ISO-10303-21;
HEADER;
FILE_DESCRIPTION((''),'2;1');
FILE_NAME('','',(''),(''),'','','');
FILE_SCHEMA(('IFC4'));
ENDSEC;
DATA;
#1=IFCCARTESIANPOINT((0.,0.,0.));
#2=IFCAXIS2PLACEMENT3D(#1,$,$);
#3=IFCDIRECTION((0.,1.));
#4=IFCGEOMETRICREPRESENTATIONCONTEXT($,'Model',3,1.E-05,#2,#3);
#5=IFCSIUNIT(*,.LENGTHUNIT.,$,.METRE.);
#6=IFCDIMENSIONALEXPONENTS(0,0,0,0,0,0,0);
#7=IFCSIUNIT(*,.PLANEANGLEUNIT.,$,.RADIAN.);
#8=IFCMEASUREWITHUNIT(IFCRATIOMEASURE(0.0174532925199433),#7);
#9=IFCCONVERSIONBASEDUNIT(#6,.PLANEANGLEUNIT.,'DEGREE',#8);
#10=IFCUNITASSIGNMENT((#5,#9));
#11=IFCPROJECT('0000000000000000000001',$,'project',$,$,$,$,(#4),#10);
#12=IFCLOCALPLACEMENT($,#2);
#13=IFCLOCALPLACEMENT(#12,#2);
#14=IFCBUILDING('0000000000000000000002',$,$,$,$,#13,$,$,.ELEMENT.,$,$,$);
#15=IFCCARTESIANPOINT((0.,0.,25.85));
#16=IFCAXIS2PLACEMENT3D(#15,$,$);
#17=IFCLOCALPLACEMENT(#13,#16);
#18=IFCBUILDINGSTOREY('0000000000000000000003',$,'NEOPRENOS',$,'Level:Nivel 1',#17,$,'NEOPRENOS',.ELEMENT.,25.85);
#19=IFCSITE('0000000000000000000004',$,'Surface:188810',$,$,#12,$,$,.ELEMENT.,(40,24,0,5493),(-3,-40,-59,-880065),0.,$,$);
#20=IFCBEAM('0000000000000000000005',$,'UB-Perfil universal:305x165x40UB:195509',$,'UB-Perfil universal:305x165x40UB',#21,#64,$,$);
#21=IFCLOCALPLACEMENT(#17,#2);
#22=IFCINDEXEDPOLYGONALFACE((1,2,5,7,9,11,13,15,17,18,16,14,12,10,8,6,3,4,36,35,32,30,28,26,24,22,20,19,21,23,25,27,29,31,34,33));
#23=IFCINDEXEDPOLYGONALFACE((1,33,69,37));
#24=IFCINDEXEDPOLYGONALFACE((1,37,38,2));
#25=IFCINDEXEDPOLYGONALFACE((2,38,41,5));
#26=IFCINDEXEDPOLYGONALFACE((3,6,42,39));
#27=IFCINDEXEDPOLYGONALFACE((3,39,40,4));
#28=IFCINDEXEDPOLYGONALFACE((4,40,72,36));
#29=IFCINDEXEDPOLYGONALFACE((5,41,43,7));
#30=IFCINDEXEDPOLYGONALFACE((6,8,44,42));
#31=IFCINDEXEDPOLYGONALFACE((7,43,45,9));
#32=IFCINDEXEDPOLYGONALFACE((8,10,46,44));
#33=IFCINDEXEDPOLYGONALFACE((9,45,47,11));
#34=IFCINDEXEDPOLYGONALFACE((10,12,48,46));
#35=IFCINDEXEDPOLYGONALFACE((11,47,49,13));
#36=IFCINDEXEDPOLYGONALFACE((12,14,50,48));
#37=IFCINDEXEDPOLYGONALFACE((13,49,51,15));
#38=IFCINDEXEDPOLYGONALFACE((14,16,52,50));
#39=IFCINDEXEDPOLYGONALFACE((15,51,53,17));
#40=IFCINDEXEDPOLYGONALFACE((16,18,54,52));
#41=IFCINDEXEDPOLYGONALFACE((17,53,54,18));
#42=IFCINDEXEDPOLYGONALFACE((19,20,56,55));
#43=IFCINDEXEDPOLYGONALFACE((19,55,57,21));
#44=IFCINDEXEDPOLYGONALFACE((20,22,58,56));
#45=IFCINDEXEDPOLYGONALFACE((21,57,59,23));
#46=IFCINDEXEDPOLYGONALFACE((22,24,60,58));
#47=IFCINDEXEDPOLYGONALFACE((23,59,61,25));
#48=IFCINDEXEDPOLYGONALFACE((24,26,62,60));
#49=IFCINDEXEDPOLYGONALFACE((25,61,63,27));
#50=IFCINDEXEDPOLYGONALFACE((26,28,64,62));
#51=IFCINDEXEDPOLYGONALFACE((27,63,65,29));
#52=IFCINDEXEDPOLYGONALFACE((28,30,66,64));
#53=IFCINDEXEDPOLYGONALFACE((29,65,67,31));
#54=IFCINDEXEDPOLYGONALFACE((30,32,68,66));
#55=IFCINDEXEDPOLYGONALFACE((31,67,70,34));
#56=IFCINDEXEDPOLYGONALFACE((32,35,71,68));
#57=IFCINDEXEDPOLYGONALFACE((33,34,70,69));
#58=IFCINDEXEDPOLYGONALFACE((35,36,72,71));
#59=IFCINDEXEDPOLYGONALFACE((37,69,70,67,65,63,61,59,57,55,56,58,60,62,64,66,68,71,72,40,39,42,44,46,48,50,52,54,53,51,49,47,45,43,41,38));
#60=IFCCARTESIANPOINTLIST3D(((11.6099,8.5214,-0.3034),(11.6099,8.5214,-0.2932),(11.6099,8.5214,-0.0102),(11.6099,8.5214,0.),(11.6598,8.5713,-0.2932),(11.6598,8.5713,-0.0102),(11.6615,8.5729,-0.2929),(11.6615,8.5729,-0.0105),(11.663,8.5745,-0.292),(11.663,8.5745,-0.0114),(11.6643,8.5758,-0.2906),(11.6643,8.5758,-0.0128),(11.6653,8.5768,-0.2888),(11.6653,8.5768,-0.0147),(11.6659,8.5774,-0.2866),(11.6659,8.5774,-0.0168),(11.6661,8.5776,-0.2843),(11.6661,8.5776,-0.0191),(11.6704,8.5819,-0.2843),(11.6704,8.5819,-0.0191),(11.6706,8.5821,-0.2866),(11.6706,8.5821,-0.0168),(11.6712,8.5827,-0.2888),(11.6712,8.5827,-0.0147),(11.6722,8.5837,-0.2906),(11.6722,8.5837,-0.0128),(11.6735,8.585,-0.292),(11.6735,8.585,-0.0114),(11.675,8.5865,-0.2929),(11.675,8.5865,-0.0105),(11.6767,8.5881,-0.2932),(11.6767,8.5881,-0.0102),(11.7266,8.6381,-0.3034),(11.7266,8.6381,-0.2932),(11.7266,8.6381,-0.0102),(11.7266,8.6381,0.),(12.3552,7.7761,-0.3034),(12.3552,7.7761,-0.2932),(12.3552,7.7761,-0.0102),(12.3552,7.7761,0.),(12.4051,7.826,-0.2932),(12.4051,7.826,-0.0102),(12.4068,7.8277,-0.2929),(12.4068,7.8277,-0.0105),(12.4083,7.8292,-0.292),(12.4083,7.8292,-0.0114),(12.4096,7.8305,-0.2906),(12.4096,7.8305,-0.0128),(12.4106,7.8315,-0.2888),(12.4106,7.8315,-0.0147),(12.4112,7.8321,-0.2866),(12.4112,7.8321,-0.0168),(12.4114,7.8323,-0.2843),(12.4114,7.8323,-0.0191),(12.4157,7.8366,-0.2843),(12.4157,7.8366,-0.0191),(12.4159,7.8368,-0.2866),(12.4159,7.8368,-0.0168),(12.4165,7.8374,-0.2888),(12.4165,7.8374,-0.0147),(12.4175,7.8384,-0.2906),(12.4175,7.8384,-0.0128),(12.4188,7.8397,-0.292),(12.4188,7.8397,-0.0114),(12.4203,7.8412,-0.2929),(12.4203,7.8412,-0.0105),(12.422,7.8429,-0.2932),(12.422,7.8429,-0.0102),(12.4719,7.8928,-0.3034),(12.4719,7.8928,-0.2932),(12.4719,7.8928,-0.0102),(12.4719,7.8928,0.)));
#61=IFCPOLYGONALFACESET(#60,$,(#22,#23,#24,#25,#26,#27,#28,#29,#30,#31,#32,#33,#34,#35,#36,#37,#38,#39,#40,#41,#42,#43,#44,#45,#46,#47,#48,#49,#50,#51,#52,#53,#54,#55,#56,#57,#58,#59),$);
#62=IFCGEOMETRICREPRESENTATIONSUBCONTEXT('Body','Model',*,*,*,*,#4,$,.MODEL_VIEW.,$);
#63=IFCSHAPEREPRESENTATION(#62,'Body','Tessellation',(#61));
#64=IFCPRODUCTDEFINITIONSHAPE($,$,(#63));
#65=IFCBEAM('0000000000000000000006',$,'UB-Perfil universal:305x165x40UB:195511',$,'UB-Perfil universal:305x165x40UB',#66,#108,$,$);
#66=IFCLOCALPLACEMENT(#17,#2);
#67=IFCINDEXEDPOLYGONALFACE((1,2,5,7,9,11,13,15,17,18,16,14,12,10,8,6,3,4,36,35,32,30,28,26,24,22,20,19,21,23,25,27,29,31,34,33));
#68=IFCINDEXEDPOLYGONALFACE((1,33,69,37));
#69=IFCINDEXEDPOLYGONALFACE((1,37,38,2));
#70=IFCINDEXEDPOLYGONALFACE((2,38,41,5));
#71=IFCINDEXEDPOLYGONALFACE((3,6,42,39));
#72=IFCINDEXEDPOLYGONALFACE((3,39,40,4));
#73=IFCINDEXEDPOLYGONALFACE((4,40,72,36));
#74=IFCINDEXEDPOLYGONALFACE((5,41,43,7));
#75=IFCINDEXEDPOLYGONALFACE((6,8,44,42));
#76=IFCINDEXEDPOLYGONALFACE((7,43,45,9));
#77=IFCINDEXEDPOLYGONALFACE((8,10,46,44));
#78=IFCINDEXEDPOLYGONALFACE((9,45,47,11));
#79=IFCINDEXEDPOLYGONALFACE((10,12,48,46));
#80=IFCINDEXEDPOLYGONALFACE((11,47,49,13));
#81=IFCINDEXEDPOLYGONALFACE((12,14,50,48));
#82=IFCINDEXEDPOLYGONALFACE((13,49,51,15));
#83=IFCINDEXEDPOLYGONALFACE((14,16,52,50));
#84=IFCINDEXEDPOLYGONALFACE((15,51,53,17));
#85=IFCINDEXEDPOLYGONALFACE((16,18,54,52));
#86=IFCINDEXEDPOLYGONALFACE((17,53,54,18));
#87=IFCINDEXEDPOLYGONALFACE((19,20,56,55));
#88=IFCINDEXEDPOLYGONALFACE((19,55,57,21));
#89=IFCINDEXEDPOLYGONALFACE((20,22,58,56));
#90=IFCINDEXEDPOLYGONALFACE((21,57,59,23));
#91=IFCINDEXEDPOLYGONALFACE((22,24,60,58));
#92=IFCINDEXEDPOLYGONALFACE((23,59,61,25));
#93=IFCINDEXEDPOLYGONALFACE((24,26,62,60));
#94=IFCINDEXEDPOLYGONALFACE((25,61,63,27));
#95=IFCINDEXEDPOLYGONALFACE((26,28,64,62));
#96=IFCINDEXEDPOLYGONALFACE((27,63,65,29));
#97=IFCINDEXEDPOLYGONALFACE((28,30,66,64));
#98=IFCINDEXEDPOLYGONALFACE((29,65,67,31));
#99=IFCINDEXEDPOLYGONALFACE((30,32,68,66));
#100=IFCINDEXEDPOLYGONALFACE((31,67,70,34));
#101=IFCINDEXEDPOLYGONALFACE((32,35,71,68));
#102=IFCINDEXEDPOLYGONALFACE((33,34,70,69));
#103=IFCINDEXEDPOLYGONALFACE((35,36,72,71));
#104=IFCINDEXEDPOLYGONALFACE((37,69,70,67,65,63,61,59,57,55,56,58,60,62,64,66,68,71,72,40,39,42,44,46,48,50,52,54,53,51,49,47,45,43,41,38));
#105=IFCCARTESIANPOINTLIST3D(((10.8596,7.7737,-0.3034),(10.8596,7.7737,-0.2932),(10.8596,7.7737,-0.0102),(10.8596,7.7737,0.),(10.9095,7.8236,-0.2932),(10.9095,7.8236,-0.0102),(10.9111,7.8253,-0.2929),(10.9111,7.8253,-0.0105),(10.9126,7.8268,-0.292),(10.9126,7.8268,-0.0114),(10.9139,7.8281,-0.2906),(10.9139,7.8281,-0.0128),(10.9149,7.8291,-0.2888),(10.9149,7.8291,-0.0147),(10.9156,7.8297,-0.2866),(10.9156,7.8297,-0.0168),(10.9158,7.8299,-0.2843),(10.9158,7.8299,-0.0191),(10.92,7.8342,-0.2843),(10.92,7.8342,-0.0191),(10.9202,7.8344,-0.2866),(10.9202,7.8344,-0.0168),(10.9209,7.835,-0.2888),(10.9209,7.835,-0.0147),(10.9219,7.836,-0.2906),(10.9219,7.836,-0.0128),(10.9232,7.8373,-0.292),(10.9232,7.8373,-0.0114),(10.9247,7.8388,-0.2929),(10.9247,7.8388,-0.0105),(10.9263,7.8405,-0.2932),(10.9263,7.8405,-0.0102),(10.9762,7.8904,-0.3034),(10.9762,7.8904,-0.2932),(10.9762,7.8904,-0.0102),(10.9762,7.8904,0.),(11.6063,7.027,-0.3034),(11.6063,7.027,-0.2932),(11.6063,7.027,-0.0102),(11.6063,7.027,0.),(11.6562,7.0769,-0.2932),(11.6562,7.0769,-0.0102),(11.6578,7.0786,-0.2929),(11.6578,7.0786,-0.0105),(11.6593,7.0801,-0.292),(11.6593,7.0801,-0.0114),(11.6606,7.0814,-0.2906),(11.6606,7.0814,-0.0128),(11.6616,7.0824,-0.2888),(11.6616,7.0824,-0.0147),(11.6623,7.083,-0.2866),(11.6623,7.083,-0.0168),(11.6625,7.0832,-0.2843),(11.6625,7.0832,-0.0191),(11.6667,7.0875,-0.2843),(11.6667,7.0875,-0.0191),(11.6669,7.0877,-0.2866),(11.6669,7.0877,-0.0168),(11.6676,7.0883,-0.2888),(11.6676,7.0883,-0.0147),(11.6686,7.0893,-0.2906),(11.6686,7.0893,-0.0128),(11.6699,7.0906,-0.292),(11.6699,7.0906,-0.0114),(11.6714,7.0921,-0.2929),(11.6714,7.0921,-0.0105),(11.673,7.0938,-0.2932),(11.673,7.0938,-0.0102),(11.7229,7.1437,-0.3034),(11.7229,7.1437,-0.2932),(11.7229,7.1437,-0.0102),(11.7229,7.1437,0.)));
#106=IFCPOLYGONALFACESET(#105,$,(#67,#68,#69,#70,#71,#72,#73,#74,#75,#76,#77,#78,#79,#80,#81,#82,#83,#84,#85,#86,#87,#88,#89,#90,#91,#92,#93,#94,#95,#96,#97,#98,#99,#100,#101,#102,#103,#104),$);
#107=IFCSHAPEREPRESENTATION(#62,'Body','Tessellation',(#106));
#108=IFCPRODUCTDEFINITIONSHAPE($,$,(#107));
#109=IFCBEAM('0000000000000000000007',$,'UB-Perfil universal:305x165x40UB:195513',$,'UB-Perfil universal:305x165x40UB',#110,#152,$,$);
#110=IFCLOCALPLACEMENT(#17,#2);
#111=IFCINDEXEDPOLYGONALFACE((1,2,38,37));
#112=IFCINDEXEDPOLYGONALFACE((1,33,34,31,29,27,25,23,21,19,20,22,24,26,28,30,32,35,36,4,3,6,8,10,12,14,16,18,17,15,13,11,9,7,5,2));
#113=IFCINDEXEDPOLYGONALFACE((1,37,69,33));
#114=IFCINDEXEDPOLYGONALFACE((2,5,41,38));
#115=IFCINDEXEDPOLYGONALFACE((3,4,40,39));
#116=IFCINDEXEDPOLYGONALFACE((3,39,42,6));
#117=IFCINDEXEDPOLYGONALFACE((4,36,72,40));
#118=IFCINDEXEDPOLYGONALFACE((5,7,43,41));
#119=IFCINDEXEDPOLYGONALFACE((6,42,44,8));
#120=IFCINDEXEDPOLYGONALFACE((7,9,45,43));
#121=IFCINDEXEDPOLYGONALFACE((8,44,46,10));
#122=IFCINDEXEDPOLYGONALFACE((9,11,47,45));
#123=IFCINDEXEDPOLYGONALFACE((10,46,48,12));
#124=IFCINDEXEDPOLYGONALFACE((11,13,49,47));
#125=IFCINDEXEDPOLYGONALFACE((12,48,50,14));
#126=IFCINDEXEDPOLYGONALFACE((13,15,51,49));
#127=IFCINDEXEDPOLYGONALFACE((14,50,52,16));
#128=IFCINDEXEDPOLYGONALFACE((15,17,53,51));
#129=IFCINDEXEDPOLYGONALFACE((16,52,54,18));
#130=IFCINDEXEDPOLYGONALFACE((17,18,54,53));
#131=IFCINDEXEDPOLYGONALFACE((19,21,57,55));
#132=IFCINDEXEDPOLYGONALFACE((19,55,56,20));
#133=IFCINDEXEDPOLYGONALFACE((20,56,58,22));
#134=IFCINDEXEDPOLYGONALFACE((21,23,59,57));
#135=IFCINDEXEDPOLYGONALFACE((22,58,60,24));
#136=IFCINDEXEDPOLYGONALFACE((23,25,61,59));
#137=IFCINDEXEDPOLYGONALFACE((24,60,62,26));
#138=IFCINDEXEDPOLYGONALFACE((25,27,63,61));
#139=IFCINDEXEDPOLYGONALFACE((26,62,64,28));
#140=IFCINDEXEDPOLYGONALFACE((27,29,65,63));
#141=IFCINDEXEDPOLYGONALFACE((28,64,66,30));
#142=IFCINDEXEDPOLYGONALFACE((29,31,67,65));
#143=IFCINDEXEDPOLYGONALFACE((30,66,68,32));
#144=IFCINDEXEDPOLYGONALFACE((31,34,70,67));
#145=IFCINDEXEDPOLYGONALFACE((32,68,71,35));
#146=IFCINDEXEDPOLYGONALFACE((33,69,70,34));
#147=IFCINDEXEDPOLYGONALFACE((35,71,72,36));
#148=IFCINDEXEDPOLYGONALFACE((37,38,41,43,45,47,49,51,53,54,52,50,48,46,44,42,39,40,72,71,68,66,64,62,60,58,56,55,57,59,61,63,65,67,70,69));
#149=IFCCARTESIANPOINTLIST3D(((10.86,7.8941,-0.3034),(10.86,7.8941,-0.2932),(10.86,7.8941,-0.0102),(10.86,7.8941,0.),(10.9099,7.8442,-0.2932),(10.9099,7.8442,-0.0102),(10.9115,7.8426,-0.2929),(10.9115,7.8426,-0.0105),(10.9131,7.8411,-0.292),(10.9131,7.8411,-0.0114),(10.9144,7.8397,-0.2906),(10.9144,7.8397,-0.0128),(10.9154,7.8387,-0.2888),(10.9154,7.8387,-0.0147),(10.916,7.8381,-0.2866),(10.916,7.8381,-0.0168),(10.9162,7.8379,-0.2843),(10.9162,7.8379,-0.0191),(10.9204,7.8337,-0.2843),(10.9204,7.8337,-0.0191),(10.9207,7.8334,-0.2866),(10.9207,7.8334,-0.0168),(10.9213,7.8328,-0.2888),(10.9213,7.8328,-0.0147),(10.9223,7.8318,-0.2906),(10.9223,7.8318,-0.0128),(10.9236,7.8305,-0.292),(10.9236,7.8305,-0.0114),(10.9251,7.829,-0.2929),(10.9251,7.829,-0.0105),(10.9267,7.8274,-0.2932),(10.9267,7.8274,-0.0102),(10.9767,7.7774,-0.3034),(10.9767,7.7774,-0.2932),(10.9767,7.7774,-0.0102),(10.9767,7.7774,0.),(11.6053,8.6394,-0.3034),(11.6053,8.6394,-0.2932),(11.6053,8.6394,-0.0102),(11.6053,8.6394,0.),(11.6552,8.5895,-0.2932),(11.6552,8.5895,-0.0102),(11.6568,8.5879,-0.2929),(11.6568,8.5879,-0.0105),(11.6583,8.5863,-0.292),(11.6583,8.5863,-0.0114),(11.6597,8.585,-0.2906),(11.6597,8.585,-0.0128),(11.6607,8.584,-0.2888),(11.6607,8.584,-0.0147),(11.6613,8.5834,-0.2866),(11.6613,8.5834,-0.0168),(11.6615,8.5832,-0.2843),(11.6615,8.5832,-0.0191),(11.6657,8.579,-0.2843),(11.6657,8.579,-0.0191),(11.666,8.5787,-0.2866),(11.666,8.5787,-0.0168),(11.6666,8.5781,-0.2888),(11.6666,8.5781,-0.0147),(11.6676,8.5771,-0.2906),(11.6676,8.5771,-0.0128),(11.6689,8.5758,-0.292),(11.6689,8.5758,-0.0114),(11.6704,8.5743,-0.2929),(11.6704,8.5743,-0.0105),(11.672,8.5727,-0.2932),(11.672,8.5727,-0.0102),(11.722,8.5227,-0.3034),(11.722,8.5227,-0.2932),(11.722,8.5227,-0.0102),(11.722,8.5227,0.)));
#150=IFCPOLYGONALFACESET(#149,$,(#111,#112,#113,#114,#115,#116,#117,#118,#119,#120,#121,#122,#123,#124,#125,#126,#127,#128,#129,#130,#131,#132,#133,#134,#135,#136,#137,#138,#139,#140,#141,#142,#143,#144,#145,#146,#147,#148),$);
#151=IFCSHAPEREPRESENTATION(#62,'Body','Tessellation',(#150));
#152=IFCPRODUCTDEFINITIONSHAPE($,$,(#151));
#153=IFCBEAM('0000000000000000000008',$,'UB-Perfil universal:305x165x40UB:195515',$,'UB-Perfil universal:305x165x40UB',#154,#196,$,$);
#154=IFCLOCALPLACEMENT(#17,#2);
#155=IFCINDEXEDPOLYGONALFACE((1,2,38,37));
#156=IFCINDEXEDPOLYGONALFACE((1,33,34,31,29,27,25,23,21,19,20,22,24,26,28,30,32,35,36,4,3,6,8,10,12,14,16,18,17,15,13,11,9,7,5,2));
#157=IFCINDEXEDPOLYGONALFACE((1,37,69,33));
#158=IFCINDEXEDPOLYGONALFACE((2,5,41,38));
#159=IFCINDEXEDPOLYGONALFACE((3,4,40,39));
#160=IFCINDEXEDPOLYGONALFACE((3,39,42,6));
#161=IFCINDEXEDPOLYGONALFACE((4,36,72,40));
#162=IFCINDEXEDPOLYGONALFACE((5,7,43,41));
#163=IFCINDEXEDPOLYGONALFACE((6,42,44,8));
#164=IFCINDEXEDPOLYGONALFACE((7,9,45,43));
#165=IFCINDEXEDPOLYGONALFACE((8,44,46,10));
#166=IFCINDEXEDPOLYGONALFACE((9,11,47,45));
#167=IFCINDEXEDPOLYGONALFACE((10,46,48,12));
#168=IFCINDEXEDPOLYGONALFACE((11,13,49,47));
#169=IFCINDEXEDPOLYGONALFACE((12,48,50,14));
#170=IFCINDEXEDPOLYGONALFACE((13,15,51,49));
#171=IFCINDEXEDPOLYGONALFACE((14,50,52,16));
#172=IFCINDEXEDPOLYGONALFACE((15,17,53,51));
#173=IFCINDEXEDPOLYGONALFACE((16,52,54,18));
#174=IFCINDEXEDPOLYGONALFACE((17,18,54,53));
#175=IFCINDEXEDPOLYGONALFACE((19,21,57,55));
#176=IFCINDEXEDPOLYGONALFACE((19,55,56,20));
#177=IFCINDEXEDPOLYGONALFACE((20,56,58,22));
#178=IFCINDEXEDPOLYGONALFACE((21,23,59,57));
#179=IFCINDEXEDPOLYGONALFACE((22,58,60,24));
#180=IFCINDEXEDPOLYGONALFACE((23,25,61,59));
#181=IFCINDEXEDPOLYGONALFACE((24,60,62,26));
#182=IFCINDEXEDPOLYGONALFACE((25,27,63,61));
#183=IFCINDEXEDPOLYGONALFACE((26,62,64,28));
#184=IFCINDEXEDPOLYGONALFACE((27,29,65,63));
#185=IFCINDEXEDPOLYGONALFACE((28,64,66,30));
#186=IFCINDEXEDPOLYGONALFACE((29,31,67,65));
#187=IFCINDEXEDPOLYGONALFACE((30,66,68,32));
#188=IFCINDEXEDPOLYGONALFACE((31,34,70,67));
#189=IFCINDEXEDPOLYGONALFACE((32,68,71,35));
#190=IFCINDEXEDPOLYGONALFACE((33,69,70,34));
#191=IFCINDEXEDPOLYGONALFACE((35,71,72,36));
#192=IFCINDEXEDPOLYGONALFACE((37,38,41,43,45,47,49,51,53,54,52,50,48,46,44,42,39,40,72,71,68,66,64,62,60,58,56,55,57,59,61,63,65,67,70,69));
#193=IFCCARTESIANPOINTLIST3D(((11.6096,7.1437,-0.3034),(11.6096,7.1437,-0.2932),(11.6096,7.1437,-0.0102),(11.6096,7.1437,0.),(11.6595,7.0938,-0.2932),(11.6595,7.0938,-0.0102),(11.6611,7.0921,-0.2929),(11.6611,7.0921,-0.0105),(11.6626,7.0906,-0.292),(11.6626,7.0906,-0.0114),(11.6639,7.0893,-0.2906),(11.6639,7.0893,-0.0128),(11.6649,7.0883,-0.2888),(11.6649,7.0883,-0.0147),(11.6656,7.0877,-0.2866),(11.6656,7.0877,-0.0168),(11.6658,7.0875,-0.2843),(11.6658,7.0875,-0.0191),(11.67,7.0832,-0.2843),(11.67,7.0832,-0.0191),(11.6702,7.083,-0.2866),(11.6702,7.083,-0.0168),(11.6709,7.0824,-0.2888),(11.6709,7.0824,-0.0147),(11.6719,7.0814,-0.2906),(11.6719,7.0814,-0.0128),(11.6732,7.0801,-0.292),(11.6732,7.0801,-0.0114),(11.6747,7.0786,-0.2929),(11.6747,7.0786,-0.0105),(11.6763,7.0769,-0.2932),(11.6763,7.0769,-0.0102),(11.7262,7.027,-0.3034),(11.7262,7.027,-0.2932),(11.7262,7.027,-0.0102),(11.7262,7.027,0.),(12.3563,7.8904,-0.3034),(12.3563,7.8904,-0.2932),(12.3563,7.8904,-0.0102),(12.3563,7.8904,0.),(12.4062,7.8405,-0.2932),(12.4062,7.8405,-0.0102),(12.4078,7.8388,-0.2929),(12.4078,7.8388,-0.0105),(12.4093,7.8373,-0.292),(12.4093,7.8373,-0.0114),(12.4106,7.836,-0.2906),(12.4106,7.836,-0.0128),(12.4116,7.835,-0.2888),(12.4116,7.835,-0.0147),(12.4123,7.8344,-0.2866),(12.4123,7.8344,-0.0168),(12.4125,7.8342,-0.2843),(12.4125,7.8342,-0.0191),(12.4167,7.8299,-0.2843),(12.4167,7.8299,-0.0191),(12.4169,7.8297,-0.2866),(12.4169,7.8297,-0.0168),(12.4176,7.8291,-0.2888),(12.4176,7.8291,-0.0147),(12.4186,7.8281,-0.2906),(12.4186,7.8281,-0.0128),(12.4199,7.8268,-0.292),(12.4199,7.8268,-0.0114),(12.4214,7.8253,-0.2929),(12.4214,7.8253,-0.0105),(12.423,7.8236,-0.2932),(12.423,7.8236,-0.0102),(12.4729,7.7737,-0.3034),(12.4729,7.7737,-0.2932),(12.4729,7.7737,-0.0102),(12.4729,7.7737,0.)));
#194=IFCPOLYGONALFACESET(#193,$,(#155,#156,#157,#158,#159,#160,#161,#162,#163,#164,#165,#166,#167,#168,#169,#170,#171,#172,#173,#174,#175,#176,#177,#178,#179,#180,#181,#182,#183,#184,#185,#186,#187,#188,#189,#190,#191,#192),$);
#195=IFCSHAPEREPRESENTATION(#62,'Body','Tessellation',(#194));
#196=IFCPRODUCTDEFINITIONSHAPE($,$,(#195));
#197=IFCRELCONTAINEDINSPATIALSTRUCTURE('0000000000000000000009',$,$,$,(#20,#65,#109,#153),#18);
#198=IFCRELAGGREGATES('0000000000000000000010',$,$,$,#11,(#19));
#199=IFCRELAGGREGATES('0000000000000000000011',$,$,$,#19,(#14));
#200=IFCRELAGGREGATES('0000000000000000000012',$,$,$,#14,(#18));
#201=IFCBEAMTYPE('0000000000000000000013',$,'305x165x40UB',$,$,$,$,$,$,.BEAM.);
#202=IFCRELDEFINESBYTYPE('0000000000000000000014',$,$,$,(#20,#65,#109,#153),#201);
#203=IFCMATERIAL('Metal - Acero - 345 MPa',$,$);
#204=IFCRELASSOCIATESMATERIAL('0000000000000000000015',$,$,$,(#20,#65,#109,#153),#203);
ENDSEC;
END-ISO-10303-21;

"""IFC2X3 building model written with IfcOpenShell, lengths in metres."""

from ifc_helpers import new_model, entity, si_unit, converted_unit, direction, frame, frame_2d, origin, place, context, subcontext, project, spatial, i_section, extrude, material, type_object, element, save


model = new_model("IFC2X3")

# Units and contexts
model_context = context("Model", 3, precision=1e-05, world=origin(), true_north=direction((0.0, 1.0)))
body_context = subcontext(model_context, "Body", "Model", "MODEL_VIEW")
ifc_project = project(units=[si_unit("LENGTHUNIT", "METRE"), converted_unit("PLANEANGLEUNIT", "DEGREE", entity("IfcRatioMeasure", 0.0174532925199433), si_unit("PLANEANGLEUNIT", "RADIAN"), dimensions=[0, 0, 0, 0, 0, 0, 0])], contexts=[model_context])

# Site, building, storey
site_placement = place(None, origin())
site = spatial("IfcSite", under=ifc_project, at=site_placement, Name="Surface:188810", CompositionType="ELEMENT", RefLatitude=(40, 24, 0, 5493), RefLongitude=(-3, -40, -59, -880065), RefElevation=0.0)
building_placement = place(site_placement, origin())
building = spatial("IfcBuilding", under=site, at=building_placement, CompositionType="ELEMENT")
storey_placement = place(building_placement, frame((0.0, 0.0, 25.85)))
storey = spatial("IfcBuildingStorey", under=building, at=storey_placement, Name="NEOPRENOS", ObjectType="Level:Nivel 1", LongName="NEOPRENOS", CompositionType="ELEMENT", Elevation=25.85)

# Beams
ifc_material_1 = material(Name="Metal - Acero - 345 MPa")
beam_type = type_object("IfcBeamType", Name="305x165x40UB", PredefinedType="BEAM")
beam_1_placement = place(storey_placement, frame((11.6663, 8.5817, 0.0), z_axis=(0.0, 0.0, 1.0), x_axis=(0.707107, -0.707107, 0.0)))
element("IfcBeam", 1, at=beam_1_placement, inside=storey, type_object=beam_type, material=ifc_material_1, Name="UB-Perfil universal:305x165x40UB:195509", ObjectType="UB-Perfil universal:305x165x40UB", context=body_context, shape_type="SweptSolid", body=[
    extrude(i_section(OverallWidth=0.165, OverallDepth=0.3034, WebThickness=0.006, FlangeThickness=0.0102, FilletRadius=0.0089, at=frame_2d((0.0, 0.0), x_axis=(0.0, 1.0))), frame((0.0028, 0.0, -0.1517), z_axis=(1.0, 0.0, 0.0), x_axis=(0.0, 0.0, -1.0)), (0.0, 0.0, 1.0), 1.054),
])
beam_2_placement = place(storey_placement, frame((11.6663, 7.0837, 0.0), z_axis=(0.0, 0.0, 1.0), x_axis=(-0.707107, 0.707107, 0.0)))
element("IfcBeam", 2, at=beam_2_placement, inside=storey, type_object=beam_type, material=ifc_material_1, Name="UB-Perfil universal:305x165x40UB:195511", ObjectType="UB-Perfil universal:305x165x40UB", context=body_context, shape_type="SweptSolid", body=[
    extrude(i_section(OverallWidth=0.165, OverallDepth=0.3034, WebThickness=0.006, FlangeThickness=0.0102, FilletRadius=0.0089, at=frame_2d((0.0, 0.0), x_axis=(0.0, 1.0))), frame((0.0023, 0.0, -0.1517), z_axis=(1.0, 0.0, 0.0), x_axis=(0.0, 0.0, -1.0)), (0.0, 0.0, 1.0), 1.056),
])
beam_3_placement = place(storey_placement, frame((10.9163, 7.8337, 0.0), z_axis=(0.0, 0.0, 1.0), x_axis=(0.707107, 0.707107, 0.0)))
element("IfcBeam", 3, at=beam_3_placement, inside=storey, type_object=beam_type, material=ifc_material_1, Name="UB-Perfil universal:305x165x40UB:195513", ObjectType="UB-Perfil universal:305x165x40UB", context=body_context, shape_type="SweptSolid", body=[
    extrude(i_section(OverallWidth=0.165, OverallDepth=0.3034, WebThickness=0.006, FlangeThickness=0.0102, FilletRadius=0.0089, at=frame_2d((0.0, 0.0), x_axis=(0.0, 1.0))), frame((0.0029, 0.0, -0.1517), z_axis=(1.0, 0.0, 0.0), x_axis=(0.0, 0.0, -1.0)), (0.0, 0.0, 1.0), 1.054),
])
beam_4_placement = place(storey_placement, frame((12.4163, 7.8337, 0.0), z_axis=(0.0, 0.0, 1.0), x_axis=(-0.707107, -0.707107, 0.0)))
element("IfcBeam", 4, at=beam_4_placement, inside=storey, type_object=beam_type, material=ifc_material_1, Name="UB-Perfil universal:305x165x40UB:195515", ObjectType="UB-Perfil universal:305x165x40UB", context=body_context, shape_type="SweptSolid", body=[
    extrude(i_section(OverallWidth=0.165, OverallDepth=0.3034, WebThickness=0.006, FlangeThickness=0.0102, FilletRadius=0.0089, at=frame_2d((0.0, 0.0), x_axis=(0.0, 1.0))), frame((0.0023, 0.0, -0.1517), z_axis=(1.0, 0.0, 0.0), x_axis=(0.0, 0.0, -1.0)), (0.0, 0.0, 1.0), 1.056),
])

save(model, "model.ifc")
